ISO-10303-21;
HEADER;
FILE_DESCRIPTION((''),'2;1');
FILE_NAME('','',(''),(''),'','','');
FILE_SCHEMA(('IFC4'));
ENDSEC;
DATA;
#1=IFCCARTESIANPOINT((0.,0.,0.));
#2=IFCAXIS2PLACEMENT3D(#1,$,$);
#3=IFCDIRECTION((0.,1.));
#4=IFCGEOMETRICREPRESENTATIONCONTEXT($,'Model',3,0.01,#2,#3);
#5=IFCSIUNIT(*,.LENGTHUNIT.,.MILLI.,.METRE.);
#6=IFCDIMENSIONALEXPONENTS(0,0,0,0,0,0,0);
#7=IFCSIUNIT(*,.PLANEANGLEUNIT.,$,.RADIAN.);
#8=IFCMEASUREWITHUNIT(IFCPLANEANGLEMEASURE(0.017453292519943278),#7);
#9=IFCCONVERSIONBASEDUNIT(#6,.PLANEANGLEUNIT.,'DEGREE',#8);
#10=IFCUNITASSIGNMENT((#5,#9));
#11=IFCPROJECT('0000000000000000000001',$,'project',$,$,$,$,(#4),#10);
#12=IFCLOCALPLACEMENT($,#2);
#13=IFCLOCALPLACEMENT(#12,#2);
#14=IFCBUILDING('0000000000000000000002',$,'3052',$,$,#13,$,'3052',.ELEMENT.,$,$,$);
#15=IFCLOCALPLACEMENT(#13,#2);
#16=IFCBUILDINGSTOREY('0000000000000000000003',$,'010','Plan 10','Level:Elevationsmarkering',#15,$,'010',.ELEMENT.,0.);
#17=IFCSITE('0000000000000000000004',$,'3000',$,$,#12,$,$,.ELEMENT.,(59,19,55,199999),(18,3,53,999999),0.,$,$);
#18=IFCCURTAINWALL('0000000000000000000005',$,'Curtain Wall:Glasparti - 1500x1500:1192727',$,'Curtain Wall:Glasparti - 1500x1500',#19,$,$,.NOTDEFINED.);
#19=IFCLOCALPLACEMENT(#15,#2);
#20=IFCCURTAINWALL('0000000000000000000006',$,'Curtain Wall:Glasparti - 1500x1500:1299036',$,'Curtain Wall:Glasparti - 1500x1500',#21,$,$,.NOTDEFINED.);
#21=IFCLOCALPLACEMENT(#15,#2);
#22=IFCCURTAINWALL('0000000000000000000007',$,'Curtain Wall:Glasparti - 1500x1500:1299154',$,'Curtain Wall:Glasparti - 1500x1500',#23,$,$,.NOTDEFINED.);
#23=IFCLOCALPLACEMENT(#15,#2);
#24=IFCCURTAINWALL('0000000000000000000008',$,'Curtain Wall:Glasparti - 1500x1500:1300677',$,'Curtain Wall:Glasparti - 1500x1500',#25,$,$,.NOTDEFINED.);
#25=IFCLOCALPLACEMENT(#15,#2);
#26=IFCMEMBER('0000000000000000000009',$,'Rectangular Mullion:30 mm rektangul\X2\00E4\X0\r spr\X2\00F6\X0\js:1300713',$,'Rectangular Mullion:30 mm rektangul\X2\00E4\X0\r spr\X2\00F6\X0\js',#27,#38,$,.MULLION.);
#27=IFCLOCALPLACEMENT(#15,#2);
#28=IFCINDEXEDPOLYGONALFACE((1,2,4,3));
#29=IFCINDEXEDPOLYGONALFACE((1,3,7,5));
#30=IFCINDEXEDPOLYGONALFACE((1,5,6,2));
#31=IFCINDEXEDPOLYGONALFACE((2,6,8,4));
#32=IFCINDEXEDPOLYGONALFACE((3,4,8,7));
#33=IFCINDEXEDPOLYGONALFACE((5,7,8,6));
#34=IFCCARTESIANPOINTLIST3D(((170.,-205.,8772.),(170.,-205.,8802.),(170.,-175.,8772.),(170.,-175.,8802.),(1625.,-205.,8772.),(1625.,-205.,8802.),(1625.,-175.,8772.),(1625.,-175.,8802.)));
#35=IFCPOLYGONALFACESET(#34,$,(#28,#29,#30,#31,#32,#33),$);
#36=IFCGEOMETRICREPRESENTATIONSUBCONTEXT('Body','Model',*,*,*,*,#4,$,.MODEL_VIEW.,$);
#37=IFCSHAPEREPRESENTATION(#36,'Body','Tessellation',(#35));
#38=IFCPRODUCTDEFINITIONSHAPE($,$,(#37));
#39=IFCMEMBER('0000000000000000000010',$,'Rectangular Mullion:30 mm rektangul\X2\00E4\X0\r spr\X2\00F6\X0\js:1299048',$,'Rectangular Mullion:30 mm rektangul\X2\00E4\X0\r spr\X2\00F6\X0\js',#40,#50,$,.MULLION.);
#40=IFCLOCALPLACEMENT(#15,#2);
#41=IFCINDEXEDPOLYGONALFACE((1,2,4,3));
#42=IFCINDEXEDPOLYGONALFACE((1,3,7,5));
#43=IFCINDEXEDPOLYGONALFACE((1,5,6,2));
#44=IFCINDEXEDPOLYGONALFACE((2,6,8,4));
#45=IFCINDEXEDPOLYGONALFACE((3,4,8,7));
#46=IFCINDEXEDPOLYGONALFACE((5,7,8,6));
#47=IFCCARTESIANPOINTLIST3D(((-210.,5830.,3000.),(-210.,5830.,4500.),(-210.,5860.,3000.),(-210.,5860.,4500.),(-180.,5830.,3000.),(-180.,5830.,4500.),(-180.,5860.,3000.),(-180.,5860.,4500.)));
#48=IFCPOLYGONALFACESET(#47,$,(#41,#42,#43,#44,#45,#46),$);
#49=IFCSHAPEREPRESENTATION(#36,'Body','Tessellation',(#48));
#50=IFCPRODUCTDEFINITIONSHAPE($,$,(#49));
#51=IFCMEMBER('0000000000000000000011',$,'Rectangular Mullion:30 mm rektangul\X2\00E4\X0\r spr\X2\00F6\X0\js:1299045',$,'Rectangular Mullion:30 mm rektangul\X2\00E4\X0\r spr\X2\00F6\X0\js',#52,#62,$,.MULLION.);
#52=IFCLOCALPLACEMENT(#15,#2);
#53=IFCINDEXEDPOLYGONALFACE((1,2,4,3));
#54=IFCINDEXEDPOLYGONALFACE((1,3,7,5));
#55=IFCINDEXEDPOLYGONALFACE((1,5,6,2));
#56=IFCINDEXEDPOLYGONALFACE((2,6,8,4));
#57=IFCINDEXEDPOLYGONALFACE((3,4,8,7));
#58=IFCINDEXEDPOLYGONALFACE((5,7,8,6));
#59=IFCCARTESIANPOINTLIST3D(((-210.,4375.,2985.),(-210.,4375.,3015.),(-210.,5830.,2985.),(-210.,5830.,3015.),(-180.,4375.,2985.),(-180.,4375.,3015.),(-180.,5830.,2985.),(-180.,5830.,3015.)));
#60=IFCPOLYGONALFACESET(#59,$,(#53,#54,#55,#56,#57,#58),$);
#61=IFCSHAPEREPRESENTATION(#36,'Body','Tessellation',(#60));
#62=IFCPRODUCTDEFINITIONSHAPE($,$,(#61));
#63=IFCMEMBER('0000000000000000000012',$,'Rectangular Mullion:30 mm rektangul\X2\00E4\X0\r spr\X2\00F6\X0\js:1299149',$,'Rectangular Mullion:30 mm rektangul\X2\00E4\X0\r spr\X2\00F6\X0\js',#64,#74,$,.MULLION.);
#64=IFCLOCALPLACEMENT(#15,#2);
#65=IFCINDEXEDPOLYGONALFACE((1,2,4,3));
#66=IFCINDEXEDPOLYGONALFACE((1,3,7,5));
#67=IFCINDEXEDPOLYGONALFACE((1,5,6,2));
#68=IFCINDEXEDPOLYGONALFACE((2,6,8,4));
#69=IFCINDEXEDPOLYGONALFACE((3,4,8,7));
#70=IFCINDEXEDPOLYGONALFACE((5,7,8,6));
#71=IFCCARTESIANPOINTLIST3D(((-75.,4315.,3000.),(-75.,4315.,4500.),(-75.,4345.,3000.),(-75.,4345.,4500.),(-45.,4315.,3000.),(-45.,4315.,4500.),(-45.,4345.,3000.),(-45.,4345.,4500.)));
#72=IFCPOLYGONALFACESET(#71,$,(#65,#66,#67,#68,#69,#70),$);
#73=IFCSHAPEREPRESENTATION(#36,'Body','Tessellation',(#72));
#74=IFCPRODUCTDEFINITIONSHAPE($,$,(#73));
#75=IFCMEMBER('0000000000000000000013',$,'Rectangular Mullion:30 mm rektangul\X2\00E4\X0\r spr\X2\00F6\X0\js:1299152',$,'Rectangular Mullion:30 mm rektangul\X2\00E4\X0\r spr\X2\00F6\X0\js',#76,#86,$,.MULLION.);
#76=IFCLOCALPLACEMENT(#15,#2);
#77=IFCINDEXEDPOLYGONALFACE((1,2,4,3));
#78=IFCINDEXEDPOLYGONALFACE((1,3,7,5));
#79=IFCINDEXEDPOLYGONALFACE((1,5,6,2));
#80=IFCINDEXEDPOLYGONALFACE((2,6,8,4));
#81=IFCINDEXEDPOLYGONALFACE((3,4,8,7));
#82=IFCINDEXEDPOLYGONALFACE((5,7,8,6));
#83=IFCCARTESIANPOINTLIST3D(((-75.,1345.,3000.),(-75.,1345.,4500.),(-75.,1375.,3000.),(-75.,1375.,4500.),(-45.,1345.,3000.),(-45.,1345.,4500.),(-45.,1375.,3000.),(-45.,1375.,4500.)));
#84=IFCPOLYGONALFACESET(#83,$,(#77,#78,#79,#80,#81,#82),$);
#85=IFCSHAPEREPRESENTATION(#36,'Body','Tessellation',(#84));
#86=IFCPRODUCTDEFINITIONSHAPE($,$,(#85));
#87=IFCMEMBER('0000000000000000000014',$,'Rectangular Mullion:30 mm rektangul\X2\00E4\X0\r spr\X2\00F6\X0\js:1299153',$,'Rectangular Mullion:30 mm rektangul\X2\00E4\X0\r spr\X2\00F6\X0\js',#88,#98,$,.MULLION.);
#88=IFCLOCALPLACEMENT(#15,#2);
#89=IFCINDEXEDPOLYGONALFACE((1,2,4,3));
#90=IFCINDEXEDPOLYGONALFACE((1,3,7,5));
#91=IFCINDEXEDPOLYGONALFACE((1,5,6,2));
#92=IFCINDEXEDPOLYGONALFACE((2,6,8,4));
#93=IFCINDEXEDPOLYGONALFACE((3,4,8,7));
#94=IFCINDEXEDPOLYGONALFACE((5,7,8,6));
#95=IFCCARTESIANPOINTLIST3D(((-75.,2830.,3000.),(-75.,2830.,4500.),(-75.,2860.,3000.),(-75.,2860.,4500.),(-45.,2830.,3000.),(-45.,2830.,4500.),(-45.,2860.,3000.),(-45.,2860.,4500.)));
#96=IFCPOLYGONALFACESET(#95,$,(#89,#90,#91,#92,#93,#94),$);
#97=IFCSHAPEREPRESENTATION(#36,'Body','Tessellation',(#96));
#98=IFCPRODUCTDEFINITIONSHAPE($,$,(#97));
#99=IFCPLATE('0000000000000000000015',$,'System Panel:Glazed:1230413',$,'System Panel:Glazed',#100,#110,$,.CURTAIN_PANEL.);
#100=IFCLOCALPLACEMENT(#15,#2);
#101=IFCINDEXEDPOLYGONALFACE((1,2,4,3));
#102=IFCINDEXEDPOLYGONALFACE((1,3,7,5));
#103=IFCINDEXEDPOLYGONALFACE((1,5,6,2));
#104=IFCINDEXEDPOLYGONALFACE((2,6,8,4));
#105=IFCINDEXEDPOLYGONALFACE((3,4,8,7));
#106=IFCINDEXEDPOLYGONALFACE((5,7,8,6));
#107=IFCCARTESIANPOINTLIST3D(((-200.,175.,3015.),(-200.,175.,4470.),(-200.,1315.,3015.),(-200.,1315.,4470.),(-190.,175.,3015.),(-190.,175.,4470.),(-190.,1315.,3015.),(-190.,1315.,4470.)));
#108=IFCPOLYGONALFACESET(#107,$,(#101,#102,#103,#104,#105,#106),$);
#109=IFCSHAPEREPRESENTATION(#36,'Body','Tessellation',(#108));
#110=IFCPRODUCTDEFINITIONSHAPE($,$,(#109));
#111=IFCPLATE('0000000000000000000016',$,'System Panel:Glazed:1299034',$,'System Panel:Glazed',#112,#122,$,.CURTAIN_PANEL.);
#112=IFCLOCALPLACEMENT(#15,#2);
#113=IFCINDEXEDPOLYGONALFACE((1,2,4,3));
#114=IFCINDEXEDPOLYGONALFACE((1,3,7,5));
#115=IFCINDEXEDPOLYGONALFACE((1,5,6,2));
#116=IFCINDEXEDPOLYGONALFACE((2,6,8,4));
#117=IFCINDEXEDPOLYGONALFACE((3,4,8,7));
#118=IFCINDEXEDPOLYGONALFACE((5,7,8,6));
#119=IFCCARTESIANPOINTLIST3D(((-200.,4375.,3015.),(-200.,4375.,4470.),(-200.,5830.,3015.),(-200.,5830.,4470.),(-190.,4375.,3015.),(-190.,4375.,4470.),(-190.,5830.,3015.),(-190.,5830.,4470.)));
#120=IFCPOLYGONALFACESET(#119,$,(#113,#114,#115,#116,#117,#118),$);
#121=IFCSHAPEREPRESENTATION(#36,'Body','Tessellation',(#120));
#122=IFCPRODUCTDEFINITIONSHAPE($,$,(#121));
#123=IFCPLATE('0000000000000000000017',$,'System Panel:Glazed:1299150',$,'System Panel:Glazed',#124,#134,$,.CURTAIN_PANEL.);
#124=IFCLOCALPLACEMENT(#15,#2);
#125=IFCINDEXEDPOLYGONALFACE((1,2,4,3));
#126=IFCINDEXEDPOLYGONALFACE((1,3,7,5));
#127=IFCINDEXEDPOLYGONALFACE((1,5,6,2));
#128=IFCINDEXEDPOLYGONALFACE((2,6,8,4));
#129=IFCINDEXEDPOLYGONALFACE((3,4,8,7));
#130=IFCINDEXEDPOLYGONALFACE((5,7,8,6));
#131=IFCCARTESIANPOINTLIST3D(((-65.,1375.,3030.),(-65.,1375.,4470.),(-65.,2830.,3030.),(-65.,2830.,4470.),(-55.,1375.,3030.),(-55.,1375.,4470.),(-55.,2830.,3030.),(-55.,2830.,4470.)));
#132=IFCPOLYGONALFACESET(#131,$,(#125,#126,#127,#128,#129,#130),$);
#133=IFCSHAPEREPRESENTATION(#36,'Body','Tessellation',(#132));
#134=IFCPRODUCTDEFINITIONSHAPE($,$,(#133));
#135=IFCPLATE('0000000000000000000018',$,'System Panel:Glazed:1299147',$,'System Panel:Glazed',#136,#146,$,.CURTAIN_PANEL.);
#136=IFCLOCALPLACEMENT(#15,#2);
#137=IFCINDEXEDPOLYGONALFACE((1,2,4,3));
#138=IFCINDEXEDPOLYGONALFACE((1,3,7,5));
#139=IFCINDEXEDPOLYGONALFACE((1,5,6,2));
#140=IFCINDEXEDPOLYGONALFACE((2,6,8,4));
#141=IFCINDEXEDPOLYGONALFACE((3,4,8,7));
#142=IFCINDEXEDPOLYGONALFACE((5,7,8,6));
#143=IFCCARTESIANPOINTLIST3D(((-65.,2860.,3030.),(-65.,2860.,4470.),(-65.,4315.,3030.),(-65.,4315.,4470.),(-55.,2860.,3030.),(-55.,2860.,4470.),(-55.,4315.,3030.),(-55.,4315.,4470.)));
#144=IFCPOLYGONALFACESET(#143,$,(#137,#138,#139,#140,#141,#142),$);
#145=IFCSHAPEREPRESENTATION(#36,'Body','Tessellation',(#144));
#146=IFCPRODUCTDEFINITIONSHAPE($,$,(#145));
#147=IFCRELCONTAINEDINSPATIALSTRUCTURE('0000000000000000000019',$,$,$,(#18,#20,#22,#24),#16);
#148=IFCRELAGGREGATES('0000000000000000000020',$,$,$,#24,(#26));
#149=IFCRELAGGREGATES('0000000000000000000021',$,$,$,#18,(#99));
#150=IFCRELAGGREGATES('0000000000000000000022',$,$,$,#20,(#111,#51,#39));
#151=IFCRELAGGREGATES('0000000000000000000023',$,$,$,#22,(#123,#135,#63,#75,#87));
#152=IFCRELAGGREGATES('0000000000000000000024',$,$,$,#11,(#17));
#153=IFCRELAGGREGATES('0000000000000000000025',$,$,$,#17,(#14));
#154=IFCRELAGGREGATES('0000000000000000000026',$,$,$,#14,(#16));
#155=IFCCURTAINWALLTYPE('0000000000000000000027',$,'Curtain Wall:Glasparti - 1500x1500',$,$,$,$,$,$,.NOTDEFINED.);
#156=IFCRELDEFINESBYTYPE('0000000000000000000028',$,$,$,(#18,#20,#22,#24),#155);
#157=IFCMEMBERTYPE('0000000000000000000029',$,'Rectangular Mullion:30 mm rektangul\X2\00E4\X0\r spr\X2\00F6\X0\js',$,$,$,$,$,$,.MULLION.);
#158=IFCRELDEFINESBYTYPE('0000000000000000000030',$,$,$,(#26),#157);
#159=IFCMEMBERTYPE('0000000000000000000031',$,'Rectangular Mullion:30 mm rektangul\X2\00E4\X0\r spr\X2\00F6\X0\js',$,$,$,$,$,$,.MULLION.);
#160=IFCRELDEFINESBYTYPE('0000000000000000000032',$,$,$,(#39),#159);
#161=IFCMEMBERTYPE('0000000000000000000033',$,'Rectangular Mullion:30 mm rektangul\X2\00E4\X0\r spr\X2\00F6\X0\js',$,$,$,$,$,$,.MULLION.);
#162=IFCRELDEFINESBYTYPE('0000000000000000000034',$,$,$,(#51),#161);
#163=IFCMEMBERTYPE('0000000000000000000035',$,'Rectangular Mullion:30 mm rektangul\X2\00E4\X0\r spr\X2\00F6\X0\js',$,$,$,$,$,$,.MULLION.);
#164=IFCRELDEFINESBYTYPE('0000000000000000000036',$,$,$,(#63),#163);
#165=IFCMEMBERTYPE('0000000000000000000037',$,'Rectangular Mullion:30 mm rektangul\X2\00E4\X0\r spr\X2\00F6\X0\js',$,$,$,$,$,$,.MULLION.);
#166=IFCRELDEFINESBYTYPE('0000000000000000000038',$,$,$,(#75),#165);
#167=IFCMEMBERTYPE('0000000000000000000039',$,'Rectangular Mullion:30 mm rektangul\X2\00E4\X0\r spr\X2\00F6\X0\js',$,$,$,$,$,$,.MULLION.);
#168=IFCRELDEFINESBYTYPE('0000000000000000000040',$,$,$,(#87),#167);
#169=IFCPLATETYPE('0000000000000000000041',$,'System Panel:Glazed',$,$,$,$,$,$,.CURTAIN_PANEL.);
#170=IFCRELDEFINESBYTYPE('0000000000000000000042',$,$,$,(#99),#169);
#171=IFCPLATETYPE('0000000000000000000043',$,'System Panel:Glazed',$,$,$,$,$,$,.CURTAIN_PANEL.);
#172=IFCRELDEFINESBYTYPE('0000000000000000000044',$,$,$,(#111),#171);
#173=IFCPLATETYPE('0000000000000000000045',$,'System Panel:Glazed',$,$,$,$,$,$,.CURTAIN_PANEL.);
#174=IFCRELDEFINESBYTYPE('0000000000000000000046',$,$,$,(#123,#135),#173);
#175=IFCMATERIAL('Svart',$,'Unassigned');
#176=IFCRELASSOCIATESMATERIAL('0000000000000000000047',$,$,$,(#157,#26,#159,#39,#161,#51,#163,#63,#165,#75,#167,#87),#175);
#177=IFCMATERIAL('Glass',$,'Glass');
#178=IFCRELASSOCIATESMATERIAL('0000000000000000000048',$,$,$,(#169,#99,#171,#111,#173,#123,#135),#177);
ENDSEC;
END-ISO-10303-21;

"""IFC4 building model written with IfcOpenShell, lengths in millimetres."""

from ifc_helpers import new_model, entity, si_unit, converted_unit, direction, frame, origin, place, context, subcontext, project, spatial, indexed_curve, outline, extrude, source, transform, mapped, material, type_object, type_shapes, element, aggregate, save


model = new_model("IFC4")

# Units and contexts
model_context = context("Model", 3, precision=0.01, world=origin(), true_north=direction((0.0, 1.0)))
body_context = subcontext(model_context, "Body", "Model", "MODEL_VIEW")
ifc_project = project(units=[si_unit("LENGTHUNIT", "METRE", prefix="MILLI"), converted_unit("PLANEANGLEUNIT", "DEGREE", entity("IfcPlaneAngleMeasure", 0.017453292519943278), si_unit("PLANEANGLEUNIT", "RADIAN"), dimensions=[0, 0, 0, 0, 0, 0, 0])], contexts=[model_context])

# Site, building, storey
site_placement = place(None, origin())
site = spatial("IfcSite", under=ifc_project, at=site_placement, Name="3000", CompositionType="ELEMENT", RefLatitude=(59, 19, 55, 199999), RefLongitude=(18, 3, 53, 999999), RefElevation=0.0)
building_placement = place(site_placement, origin())
building = spatial("IfcBuilding", under=site, at=building_placement, Name="3052", LongName="3052", CompositionType="ELEMENT")
storey_placement = place(building_placement, origin())
storey = spatial("IfcBuildingStorey", under=building, at=storey_placement, Name="010", Description="Plan 10", ObjectType="Level:Elevationsmarkering", LongName="010", CompositionType="ELEMENT", Elevation=0.0)

# Curtain walls
curtain_wall_type = type_object("IfcCurtainWallType", Name="Curtain Wall:Glasparti - 1500x1500", PredefinedType="NOTDEFINED")
curtain_wall_1_placement = place(storey_placement, origin())
curtain_wall_1 = element("IfcCurtainWall", 1, at=curtain_wall_1_placement, inside=storey, type_object=curtain_wall_type, Name="Curtain Wall:Glasparti - 1500x1500:1192727", ObjectType="Curtain Wall:Glasparti - 1500x1500", PredefinedType="NOTDEFINED")
ifc_material_1 = material(Name="Svart", Category="Unassigned")
curtain_wall_2_placement = place(storey_placement, origin())
curtain_wall_2 = element("IfcCurtainWall", 2, at=curtain_wall_2_placement, inside=storey, type_object=curtain_wall_type, Name="Curtain Wall:Glasparti - 1500x1500:1299036", ObjectType="Curtain Wall:Glasparti - 1500x1500", PredefinedType="NOTDEFINED")

# Curtain wall
curtain_wall_3_placement = place(storey_placement, origin())
curtain_wall_3 = element("IfcCurtainWall", 3, at=curtain_wall_3_placement, inside=storey, type_object=curtain_wall_type, Name="Curtain Wall:Glasparti - 1500x1500:1299154", ObjectType="Curtain Wall:Glasparti - 1500x1500", PredefinedType="NOTDEFINED")
member_type_1 = type_object("IfcMemberType", Name="Rectangular Mullion:30 mm rektangulär spröjs", PredefinedType="MULLION", material=ifc_material_1)
shared_shape_1 = source(origin(), body_context, "Body", "SweptSolid", [
    extrude(outline(indexed_curve([(-15.0, -15.0), (15.0, -15.0), (15.0, 15.0), (-15.0, 15.0), (-15.0, -15.0)], self_intersect=False)), frame((-15.0, 0.0, -1455.0), z_axis=(0.0, 0.0, 1.0), x_axis=(-1.0, 0.0, 0.0)), (0.0, 0.0, 1.0), 1455.0),
])
type_shapes(member_type_1, [shared_shape_1])

# Curtain wall, member
curtain_wall_4_placement = place(storey_placement, origin())
curtain_wall_4 = element("IfcCurtainWall", 4, at=curtain_wall_4_placement, inside=storey, type_object=curtain_wall_type, Name="Curtain Wall:Glasparti - 1500x1500:1300677", ObjectType="Curtain Wall:Glasparti - 1500x1500", PredefinedType="NOTDEFINED")
member_1_placement = place(curtain_wall_4_placement, frame((1625.0, -190.0, 8802.0), z_axis=(1.0, 0.0, 0.0), x_axis=(0.0, 0.0, 1.0)))
member_1 = element("IfcMember", 5, at=member_1_placement, type_object=member_type_1, material=ifc_material_1, Name="Rectangular Mullion:30 mm rektangulär spröjs:1300713", ObjectType="Rectangular Mullion:30 mm rektangulär spröjs", PredefinedType="MULLION", context=body_context, shape_type="MappedRepresentation", body=[
    mapped(shared_shape_1, transform((0.0, 0.0, 0.0), scale=1.0)),
])
aggregate(curtain_wall_4, [member_1])

# Members
member_type_2 = type_object("IfcMemberType", Name="Rectangular Mullion:30 mm rektangulär spröjs", PredefinedType="MULLION", material=ifc_material_1)
shared_shape_2 = source(origin(), body_context, "Body", "SweptSolid", [
    extrude(outline(indexed_curve([(-15.0, -15.0), (15.0, -15.0), (15.0, 15.0), (-15.0, 15.0), (-15.0, -15.0)], self_intersect=False)), frame((0.0, 0.0, -1500.0), z_axis=(0.0, 0.0, 1.0), x_axis=(-1.0, 0.0, 0.0)), (0.0, 0.0, 1.0), 1500.0),
])
type_shapes(member_type_2, [shared_shape_2])
member_2_placement = place(curtain_wall_2_placement, frame((-195.0, 5845.0, 3000.0), z_axis=(0.0, 0.0, -1.0), x_axis=(0.0, 1.0, 0.0)))
member_2 = element("IfcMember", 6, at=member_2_placement, type_object=member_type_2, material=ifc_material_1, Name="Rectangular Mullion:30 mm rektangulär spröjs:1299048", ObjectType="Rectangular Mullion:30 mm rektangulär spröjs", PredefinedType="MULLION", context=body_context, shape_type="MappedRepresentation", body=[
    mapped(shared_shape_2, transform((0.0, 0.0, 0.0), scale=1.0)),
])
member_type_3 = type_object("IfcMemberType", Name="Rectangular Mullion:30 mm rektangulär spröjs", PredefinedType="MULLION", material=ifc_material_1)
shared_shape_3 = source(origin(), body_context, "Body", "SweptSolid", [
    extrude(outline(indexed_curve([(-15.0, -15.0), (15.0, -15.0), (15.0, 15.0), (-15.0, 15.0), (-15.0, -15.0)], self_intersect=False)), frame((0.0, 0.0, -1455.0), z_axis=(0.0, 0.0, 1.0), x_axis=(-1.0, 0.0, 0.0)), (0.0, 0.0, 1.0), 1455.0),
])
type_shapes(member_type_3, [shared_shape_3])
member_3_placement = place(curtain_wall_2_placement, frame((-195.0, 5830.0, 3000.0), z_axis=(0.0, 1.0, 0.0), x_axis=(0.0, 0.0, 1.0)))
member_3 = element("IfcMember", 7, at=member_3_placement, type_object=member_type_3, material=ifc_material_1, Name="Rectangular Mullion:30 mm rektangulär spröjs:1299045", ObjectType="Rectangular Mullion:30 mm rektangulär spröjs", PredefinedType="MULLION", context=body_context, shape_type="MappedRepresentation", body=[
    mapped(shared_shape_3, transform((0.0, 0.0, 0.0), scale=1.0)),
])
member_type_4 = type_object("IfcMemberType", Name="Rectangular Mullion:30 mm rektangulär spröjs", PredefinedType="MULLION", material=ifc_material_1)
shared_shape_4 = source(origin(), body_context, "Body", "SweptSolid", [
    extrude(outline(indexed_curve([(-15.0, -15.0), (15.0, -15.0), (15.0, 15.0), (-15.0, 15.0), (-15.0, -15.0)], self_intersect=False)), frame((-15.0, 0.0, -1500.0), z_axis=(0.0, 0.0, 1.0), x_axis=(-1.0, 0.0, 0.0)), (0.0, 0.0, 1.0), 1500.0),
])
type_shapes(member_type_4, [shared_shape_4])
member_4_placement = place(curtain_wall_3_placement, frame((-60.0, 4345.0, 3000.0), z_axis=(0.0, 0.0, -1.0), x_axis=(0.0, 1.0, 0.0)))
member_4 = element("IfcMember", 8, at=member_4_placement, type_object=member_type_4, material=ifc_material_1, Name="Rectangular Mullion:30 mm rektangulär spröjs:1299149", ObjectType="Rectangular Mullion:30 mm rektangulär spröjs", PredefinedType="MULLION", context=body_context, shape_type="MappedRepresentation", body=[
    mapped(shared_shape_4, transform((0.0, 0.0, 0.0), scale=1.0)),
])
member_type_5 = type_object("IfcMemberType", Name="Rectangular Mullion:30 mm rektangulär spröjs", PredefinedType="MULLION", material=ifc_material_1)
shared_shape_5 = source(origin(), body_context, "Body", "SweptSolid", [
    extrude(outline(indexed_curve([(-15.0, -15.0), (15.0, -15.0), (15.0, 15.0), (-15.0, 15.0), (-15.0, -15.0)], self_intersect=False)), frame((-15.0, 0.0, -1500.0), z_axis=(0.0, 0.0, 1.0), x_axis=(-1.0, 0.0, 0.0)), (0.0, 0.0, 1.0), 1500.0),
])
type_shapes(member_type_5, [shared_shape_5])
member_5_placement = place(curtain_wall_3_placement, frame((-60.0, 1345.0, 4500.0), z_axis=(0.0, 0.0, 1.0), x_axis=(0.0, -1.0, 0.0)))
member_5 = element("IfcMember", 9, at=member_5_placement, type_object=member_type_5, material=ifc_material_1, Name="Rectangular Mullion:30 mm rektangulär spröjs:1299152", ObjectType="Rectangular Mullion:30 mm rektangulär spröjs", PredefinedType="MULLION", context=body_context, shape_type="MappedRepresentation", body=[
    mapped(shared_shape_5, transform((0.0, 0.0, 0.0), scale=1.0)),
])
member_type_6 = type_object("IfcMemberType", Name="Rectangular Mullion:30 mm rektangulär spröjs", PredefinedType="MULLION", material=ifc_material_1)
shared_shape_6 = source(origin(), body_context, "Body", "SweptSolid", [
    extrude(outline(indexed_curve([(-15.0, -15.0), (15.0, -15.0), (15.0, 15.0), (-15.0, 15.0), (-15.0, -15.0)], self_intersect=False)), frame((0.0, 0.0, -1500.0), z_axis=(0.0, 0.0, 1.0), x_axis=(-1.0, 0.0, 0.0)), (0.0, 0.0, 1.0), 1500.0),
])
type_shapes(member_type_6, [shared_shape_6])
member_6_placement = place(curtain_wall_3_placement, frame((-60.0, 2845.0, 3000.0), z_axis=(0.0, 0.0, -1.0), x_axis=(0.0, 1.0, 0.0)))
member_6 = element("IfcMember", 10, at=member_6_placement, type_object=member_type_6, material=ifc_material_1, Name="Rectangular Mullion:30 mm rektangulär spröjs:1299153", ObjectType="Rectangular Mullion:30 mm rektangulär spröjs", PredefinedType="MULLION", context=body_context, shape_type="MappedRepresentation", body=[
    mapped(shared_shape_6, transform((0.0, 0.0, 0.0), scale=1.0)),
])

# Plates
ifc_material_2 = material(Name="Glass", Category="Glass")
plate_type_1 = type_object("IfcPlateType", Name="System Panel:Glazed", PredefinedType="CURTAIN_PANEL", material=ifc_material_2)
shared_shape_7 = source(origin(), body_context, "Body", "SweptSolid", [
    extrude(outline(indexed_curve([(-5.0, -570.0), (5.0, -570.0), (5.0, 570.0), (-5.0, 570.0), (-5.0, -570.0)], self_intersect=False)), frame((0.0, 0.0, 0.0), z_axis=(0.0, 0.0, 1.0), x_axis=(0.0, 1.0, 0.0)), (0.0, 0.0, 1.0), 1455.0),
])
type_shapes(plate_type_1, [shared_shape_7])
plate_1_placement = place(curtain_wall_1_placement, frame((-195.0, 745.0, 3015.0), z_axis=(0.0, 0.0, 1.0), x_axis=(0.0, 1.0, 0.0)))
plate_1 = element("IfcPlate", 11, at=plate_1_placement, type_object=plate_type_1, material=ifc_material_2, Name="System Panel:Glazed:1230413", ObjectType="System Panel:Glazed", PredefinedType="CURTAIN_PANEL", context=body_context, shape_type="MappedRepresentation", body=[
    mapped(shared_shape_7, transform((0.0, 0.0, 0.0), scale=1.0)),
])
aggregate(curtain_wall_1, [plate_1])
plate_type_2 = type_object("IfcPlateType", Name="System Panel:Glazed", PredefinedType="CURTAIN_PANEL", material=ifc_material_2)
shared_shape_8 = source(origin(), body_context, "Body", "SweptSolid", [
    extrude(outline(indexed_curve([(-5.0, -727.5), (5.0, -727.5), (5.0, 727.5), (-5.0, 727.5), (-5.0, -727.5)], self_intersect=False)), frame((0.0, 0.0, 0.0), z_axis=(0.0, 0.0, 1.0), x_axis=(0.0, 1.0, 0.0)), (0.0, 0.0, 1.0), 1455.0),
])
type_shapes(plate_type_2, [shared_shape_8])
plate_2_placement = place(curtain_wall_2_placement, frame((-195.0, 5102.5, 3015.0), z_axis=(0.0, 0.0, 1.0), x_axis=(0.0, 1.0, 0.0)))
plate_2 = element("IfcPlate", 12, at=plate_2_placement, type_object=plate_type_2, material=ifc_material_2, Name="System Panel:Glazed:1299034", ObjectType="System Panel:Glazed", PredefinedType="CURTAIN_PANEL", context=body_context, shape_type="MappedRepresentation", body=[
    mapped(shared_shape_8, transform((0.0, 0.0, 0.0), scale=1.0)),
])
aggregate(curtain_wall_2, [plate_2, member_3, member_2])
plate_type_3 = type_object("IfcPlateType", Name="System Panel:Glazed", PredefinedType="CURTAIN_PANEL", material=ifc_material_2)
shared_shape_9 = source(origin(), body_context, "Body", "SweptSolid", [
    extrude(outline(indexed_curve([(-5.0, -727.5), (5.0, -727.5), (5.0, 727.5), (-5.0, 727.5), (-5.0, -727.5)], self_intersect=False)), frame((0.0, 0.0, 0.0), z_axis=(0.0, 0.0, 1.0), x_axis=(0.0, 1.0, 0.0)), (0.0, 0.0, 1.0), 1440.0),
])
type_shapes(plate_type_3, [shared_shape_9])
plate_3_placement = place(curtain_wall_3_placement, frame((-60.0, 2102.5, 3030.0), z_axis=(0.0, 0.0, 1.0), x_axis=(0.0, 1.0, 0.0)))
plate_3 = element("IfcPlate", 13, at=plate_3_placement, type_object=plate_type_3, material=ifc_material_2, Name="System Panel:Glazed:1299150", ObjectType="System Panel:Glazed", PredefinedType="CURTAIN_PANEL", context=body_context, shape_type="MappedRepresentation", body=[
    mapped(shared_shape_9, transform((0.0, 0.0, 0.0), scale=1.0)),
])
plate_4_placement = place(curtain_wall_3_placement, frame((-60.0, 3587.5, 3030.0), z_axis=(0.0, 0.0, 1.0), x_axis=(0.0, 1.0, 0.0)))
plate_4 = element("IfcPlate", 14, at=plate_4_placement, type_object=plate_type_3, material=ifc_material_2, Name="System Panel:Glazed:1299147", ObjectType="System Panel:Glazed", PredefinedType="CURTAIN_PANEL", context=body_context, shape_type="MappedRepresentation", body=[
    mapped(shared_shape_9, transform((0.0, 0.0, 0.0), scale=1.0)),
])
aggregate(curtain_wall_3, [plate_3, plate_4, member_4, member_5, member_6])

save(model, "model.ifc")
